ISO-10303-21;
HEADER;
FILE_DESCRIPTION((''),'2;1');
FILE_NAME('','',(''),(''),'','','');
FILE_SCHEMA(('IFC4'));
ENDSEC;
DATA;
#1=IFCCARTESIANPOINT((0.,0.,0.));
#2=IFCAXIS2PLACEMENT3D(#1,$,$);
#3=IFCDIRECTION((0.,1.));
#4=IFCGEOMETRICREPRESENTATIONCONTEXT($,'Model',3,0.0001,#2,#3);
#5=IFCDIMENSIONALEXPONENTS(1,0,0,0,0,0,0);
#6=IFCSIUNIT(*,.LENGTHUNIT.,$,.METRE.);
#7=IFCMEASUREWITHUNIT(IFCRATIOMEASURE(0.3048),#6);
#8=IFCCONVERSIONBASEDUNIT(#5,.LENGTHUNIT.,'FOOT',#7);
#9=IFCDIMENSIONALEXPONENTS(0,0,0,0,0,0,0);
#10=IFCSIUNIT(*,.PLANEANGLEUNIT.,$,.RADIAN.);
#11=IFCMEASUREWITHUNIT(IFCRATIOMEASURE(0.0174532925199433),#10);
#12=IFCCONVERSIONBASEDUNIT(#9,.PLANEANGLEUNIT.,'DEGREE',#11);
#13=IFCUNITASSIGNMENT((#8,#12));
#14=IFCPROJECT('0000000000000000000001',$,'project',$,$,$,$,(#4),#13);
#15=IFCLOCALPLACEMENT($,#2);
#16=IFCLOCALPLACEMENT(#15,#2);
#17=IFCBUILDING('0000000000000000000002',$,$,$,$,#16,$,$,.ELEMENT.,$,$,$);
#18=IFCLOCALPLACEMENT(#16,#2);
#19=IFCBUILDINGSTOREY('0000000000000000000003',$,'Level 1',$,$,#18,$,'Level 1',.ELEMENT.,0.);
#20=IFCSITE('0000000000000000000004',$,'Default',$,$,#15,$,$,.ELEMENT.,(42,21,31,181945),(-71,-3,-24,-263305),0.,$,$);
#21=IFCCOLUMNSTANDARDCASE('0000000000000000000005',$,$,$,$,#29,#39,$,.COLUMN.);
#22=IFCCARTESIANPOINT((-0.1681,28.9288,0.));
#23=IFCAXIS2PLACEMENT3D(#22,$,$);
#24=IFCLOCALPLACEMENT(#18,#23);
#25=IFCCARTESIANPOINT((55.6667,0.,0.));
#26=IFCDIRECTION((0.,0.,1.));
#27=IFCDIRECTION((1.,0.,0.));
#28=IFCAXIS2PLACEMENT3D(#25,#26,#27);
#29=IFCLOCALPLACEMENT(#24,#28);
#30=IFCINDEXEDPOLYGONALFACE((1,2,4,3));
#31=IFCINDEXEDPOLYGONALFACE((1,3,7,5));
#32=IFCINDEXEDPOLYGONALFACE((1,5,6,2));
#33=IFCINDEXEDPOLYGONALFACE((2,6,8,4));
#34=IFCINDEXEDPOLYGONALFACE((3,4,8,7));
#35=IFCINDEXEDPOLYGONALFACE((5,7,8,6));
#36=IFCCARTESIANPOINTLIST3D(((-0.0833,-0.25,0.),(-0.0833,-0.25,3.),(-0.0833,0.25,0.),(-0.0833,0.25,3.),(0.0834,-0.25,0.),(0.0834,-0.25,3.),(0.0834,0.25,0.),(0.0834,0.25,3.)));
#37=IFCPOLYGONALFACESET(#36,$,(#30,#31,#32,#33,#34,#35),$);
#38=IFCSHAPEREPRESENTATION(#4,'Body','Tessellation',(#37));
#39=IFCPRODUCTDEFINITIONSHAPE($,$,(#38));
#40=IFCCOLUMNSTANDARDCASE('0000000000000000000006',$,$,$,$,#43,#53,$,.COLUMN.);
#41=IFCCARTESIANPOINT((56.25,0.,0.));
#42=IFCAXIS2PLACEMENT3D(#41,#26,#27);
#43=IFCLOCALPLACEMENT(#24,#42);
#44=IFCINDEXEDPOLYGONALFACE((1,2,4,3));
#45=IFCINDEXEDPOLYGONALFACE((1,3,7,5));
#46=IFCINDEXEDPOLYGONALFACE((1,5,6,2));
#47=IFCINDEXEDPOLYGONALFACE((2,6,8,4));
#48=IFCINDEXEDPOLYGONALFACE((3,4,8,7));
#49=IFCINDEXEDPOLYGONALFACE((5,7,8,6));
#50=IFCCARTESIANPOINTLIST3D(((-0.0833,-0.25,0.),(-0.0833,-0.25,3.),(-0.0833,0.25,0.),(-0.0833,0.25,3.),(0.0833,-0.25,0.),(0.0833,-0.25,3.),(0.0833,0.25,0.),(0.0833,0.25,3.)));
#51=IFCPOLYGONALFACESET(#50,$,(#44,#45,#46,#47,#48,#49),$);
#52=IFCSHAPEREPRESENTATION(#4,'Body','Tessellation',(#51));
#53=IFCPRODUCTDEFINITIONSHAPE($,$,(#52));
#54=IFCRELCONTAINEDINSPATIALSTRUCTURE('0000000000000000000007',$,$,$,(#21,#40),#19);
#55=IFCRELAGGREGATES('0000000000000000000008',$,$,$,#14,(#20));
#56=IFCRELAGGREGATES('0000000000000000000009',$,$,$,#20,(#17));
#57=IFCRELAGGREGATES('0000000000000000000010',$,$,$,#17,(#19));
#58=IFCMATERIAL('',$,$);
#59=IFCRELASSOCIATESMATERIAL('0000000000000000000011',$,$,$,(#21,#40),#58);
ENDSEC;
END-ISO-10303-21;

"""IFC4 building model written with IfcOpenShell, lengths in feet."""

from ifc_helpers import new_model, entity, si_unit, converted_unit, direction, frame, origin, place, context, project, spatial, rectangle, extrude, material, element, save


model = new_model("IFC4")

# Units and contexts
model_context = context("Model", 3, precision=0.0001, world=origin(), true_north=direction((0.0, 1.0)))
ifc_project = project(units=[converted_unit("LENGTHUNIT", "FOOT", entity("IfcRatioMeasure", 0.3048), si_unit("LENGTHUNIT", "METRE"), dimensions=[1, 0, 0, 0, 0, 0, 0]), converted_unit("PLANEANGLEUNIT", "DEGREE", entity("IfcRatioMeasure", 0.0174532925199433), si_unit("PLANEANGLEUNIT", "RADIAN"), dimensions=[0, 0, 0, 0, 0, 0, 0])], contexts=[model_context])

# Site, building, storey
site_placement = place(None, origin())
site = spatial("IfcSite", under=ifc_project, at=site_placement, Name="Default", CompositionType="ELEMENT", RefLatitude=(42, 21, 31, 181945), RefLongitude=(-71, -3, -24, -263305), RefElevation=0.0)
building_placement = place(site_placement, origin())
building = spatial("IfcBuilding", under=site, at=building_placement, CompositionType="ELEMENT")
storey_placement = place(building_placement, origin())
storey = spatial("IfcBuildingStorey", under=building, at=storey_placement, Name="Level 1", LongName="Level 1", CompositionType="ELEMENT", Elevation=0.0)

# Columns
ifc_material = material(Name="")
placement = place(storey_placement, frame((-0.1681, 28.9288, 0.0)))
for number, where, z_axis, x_axis in (
    (1, (55.6667, 0.0, 0.0), (0.0, 0.0, 1.0), (1.0, 0.0, 0.0)),
    (2, (56.25, 0.0, 0.0), (0.0, 0.0, 1.0), (1.0, 0.0, 0.0)),
):
    element("IfcColumnStandardCase", number, at=place(placement, frame(where, z_axis=z_axis, x_axis=x_axis)), inside=storey, material=ifc_material, PredefinedType="COLUMN", context=model_context, shape_type="SweptSolid", body=[
        extrude(rectangle(XDim=0.1667, YDim=0.5), origin(), (0.0, 0.0, 1.0), 3.0),
    ])

save(model, "model.ifc")
